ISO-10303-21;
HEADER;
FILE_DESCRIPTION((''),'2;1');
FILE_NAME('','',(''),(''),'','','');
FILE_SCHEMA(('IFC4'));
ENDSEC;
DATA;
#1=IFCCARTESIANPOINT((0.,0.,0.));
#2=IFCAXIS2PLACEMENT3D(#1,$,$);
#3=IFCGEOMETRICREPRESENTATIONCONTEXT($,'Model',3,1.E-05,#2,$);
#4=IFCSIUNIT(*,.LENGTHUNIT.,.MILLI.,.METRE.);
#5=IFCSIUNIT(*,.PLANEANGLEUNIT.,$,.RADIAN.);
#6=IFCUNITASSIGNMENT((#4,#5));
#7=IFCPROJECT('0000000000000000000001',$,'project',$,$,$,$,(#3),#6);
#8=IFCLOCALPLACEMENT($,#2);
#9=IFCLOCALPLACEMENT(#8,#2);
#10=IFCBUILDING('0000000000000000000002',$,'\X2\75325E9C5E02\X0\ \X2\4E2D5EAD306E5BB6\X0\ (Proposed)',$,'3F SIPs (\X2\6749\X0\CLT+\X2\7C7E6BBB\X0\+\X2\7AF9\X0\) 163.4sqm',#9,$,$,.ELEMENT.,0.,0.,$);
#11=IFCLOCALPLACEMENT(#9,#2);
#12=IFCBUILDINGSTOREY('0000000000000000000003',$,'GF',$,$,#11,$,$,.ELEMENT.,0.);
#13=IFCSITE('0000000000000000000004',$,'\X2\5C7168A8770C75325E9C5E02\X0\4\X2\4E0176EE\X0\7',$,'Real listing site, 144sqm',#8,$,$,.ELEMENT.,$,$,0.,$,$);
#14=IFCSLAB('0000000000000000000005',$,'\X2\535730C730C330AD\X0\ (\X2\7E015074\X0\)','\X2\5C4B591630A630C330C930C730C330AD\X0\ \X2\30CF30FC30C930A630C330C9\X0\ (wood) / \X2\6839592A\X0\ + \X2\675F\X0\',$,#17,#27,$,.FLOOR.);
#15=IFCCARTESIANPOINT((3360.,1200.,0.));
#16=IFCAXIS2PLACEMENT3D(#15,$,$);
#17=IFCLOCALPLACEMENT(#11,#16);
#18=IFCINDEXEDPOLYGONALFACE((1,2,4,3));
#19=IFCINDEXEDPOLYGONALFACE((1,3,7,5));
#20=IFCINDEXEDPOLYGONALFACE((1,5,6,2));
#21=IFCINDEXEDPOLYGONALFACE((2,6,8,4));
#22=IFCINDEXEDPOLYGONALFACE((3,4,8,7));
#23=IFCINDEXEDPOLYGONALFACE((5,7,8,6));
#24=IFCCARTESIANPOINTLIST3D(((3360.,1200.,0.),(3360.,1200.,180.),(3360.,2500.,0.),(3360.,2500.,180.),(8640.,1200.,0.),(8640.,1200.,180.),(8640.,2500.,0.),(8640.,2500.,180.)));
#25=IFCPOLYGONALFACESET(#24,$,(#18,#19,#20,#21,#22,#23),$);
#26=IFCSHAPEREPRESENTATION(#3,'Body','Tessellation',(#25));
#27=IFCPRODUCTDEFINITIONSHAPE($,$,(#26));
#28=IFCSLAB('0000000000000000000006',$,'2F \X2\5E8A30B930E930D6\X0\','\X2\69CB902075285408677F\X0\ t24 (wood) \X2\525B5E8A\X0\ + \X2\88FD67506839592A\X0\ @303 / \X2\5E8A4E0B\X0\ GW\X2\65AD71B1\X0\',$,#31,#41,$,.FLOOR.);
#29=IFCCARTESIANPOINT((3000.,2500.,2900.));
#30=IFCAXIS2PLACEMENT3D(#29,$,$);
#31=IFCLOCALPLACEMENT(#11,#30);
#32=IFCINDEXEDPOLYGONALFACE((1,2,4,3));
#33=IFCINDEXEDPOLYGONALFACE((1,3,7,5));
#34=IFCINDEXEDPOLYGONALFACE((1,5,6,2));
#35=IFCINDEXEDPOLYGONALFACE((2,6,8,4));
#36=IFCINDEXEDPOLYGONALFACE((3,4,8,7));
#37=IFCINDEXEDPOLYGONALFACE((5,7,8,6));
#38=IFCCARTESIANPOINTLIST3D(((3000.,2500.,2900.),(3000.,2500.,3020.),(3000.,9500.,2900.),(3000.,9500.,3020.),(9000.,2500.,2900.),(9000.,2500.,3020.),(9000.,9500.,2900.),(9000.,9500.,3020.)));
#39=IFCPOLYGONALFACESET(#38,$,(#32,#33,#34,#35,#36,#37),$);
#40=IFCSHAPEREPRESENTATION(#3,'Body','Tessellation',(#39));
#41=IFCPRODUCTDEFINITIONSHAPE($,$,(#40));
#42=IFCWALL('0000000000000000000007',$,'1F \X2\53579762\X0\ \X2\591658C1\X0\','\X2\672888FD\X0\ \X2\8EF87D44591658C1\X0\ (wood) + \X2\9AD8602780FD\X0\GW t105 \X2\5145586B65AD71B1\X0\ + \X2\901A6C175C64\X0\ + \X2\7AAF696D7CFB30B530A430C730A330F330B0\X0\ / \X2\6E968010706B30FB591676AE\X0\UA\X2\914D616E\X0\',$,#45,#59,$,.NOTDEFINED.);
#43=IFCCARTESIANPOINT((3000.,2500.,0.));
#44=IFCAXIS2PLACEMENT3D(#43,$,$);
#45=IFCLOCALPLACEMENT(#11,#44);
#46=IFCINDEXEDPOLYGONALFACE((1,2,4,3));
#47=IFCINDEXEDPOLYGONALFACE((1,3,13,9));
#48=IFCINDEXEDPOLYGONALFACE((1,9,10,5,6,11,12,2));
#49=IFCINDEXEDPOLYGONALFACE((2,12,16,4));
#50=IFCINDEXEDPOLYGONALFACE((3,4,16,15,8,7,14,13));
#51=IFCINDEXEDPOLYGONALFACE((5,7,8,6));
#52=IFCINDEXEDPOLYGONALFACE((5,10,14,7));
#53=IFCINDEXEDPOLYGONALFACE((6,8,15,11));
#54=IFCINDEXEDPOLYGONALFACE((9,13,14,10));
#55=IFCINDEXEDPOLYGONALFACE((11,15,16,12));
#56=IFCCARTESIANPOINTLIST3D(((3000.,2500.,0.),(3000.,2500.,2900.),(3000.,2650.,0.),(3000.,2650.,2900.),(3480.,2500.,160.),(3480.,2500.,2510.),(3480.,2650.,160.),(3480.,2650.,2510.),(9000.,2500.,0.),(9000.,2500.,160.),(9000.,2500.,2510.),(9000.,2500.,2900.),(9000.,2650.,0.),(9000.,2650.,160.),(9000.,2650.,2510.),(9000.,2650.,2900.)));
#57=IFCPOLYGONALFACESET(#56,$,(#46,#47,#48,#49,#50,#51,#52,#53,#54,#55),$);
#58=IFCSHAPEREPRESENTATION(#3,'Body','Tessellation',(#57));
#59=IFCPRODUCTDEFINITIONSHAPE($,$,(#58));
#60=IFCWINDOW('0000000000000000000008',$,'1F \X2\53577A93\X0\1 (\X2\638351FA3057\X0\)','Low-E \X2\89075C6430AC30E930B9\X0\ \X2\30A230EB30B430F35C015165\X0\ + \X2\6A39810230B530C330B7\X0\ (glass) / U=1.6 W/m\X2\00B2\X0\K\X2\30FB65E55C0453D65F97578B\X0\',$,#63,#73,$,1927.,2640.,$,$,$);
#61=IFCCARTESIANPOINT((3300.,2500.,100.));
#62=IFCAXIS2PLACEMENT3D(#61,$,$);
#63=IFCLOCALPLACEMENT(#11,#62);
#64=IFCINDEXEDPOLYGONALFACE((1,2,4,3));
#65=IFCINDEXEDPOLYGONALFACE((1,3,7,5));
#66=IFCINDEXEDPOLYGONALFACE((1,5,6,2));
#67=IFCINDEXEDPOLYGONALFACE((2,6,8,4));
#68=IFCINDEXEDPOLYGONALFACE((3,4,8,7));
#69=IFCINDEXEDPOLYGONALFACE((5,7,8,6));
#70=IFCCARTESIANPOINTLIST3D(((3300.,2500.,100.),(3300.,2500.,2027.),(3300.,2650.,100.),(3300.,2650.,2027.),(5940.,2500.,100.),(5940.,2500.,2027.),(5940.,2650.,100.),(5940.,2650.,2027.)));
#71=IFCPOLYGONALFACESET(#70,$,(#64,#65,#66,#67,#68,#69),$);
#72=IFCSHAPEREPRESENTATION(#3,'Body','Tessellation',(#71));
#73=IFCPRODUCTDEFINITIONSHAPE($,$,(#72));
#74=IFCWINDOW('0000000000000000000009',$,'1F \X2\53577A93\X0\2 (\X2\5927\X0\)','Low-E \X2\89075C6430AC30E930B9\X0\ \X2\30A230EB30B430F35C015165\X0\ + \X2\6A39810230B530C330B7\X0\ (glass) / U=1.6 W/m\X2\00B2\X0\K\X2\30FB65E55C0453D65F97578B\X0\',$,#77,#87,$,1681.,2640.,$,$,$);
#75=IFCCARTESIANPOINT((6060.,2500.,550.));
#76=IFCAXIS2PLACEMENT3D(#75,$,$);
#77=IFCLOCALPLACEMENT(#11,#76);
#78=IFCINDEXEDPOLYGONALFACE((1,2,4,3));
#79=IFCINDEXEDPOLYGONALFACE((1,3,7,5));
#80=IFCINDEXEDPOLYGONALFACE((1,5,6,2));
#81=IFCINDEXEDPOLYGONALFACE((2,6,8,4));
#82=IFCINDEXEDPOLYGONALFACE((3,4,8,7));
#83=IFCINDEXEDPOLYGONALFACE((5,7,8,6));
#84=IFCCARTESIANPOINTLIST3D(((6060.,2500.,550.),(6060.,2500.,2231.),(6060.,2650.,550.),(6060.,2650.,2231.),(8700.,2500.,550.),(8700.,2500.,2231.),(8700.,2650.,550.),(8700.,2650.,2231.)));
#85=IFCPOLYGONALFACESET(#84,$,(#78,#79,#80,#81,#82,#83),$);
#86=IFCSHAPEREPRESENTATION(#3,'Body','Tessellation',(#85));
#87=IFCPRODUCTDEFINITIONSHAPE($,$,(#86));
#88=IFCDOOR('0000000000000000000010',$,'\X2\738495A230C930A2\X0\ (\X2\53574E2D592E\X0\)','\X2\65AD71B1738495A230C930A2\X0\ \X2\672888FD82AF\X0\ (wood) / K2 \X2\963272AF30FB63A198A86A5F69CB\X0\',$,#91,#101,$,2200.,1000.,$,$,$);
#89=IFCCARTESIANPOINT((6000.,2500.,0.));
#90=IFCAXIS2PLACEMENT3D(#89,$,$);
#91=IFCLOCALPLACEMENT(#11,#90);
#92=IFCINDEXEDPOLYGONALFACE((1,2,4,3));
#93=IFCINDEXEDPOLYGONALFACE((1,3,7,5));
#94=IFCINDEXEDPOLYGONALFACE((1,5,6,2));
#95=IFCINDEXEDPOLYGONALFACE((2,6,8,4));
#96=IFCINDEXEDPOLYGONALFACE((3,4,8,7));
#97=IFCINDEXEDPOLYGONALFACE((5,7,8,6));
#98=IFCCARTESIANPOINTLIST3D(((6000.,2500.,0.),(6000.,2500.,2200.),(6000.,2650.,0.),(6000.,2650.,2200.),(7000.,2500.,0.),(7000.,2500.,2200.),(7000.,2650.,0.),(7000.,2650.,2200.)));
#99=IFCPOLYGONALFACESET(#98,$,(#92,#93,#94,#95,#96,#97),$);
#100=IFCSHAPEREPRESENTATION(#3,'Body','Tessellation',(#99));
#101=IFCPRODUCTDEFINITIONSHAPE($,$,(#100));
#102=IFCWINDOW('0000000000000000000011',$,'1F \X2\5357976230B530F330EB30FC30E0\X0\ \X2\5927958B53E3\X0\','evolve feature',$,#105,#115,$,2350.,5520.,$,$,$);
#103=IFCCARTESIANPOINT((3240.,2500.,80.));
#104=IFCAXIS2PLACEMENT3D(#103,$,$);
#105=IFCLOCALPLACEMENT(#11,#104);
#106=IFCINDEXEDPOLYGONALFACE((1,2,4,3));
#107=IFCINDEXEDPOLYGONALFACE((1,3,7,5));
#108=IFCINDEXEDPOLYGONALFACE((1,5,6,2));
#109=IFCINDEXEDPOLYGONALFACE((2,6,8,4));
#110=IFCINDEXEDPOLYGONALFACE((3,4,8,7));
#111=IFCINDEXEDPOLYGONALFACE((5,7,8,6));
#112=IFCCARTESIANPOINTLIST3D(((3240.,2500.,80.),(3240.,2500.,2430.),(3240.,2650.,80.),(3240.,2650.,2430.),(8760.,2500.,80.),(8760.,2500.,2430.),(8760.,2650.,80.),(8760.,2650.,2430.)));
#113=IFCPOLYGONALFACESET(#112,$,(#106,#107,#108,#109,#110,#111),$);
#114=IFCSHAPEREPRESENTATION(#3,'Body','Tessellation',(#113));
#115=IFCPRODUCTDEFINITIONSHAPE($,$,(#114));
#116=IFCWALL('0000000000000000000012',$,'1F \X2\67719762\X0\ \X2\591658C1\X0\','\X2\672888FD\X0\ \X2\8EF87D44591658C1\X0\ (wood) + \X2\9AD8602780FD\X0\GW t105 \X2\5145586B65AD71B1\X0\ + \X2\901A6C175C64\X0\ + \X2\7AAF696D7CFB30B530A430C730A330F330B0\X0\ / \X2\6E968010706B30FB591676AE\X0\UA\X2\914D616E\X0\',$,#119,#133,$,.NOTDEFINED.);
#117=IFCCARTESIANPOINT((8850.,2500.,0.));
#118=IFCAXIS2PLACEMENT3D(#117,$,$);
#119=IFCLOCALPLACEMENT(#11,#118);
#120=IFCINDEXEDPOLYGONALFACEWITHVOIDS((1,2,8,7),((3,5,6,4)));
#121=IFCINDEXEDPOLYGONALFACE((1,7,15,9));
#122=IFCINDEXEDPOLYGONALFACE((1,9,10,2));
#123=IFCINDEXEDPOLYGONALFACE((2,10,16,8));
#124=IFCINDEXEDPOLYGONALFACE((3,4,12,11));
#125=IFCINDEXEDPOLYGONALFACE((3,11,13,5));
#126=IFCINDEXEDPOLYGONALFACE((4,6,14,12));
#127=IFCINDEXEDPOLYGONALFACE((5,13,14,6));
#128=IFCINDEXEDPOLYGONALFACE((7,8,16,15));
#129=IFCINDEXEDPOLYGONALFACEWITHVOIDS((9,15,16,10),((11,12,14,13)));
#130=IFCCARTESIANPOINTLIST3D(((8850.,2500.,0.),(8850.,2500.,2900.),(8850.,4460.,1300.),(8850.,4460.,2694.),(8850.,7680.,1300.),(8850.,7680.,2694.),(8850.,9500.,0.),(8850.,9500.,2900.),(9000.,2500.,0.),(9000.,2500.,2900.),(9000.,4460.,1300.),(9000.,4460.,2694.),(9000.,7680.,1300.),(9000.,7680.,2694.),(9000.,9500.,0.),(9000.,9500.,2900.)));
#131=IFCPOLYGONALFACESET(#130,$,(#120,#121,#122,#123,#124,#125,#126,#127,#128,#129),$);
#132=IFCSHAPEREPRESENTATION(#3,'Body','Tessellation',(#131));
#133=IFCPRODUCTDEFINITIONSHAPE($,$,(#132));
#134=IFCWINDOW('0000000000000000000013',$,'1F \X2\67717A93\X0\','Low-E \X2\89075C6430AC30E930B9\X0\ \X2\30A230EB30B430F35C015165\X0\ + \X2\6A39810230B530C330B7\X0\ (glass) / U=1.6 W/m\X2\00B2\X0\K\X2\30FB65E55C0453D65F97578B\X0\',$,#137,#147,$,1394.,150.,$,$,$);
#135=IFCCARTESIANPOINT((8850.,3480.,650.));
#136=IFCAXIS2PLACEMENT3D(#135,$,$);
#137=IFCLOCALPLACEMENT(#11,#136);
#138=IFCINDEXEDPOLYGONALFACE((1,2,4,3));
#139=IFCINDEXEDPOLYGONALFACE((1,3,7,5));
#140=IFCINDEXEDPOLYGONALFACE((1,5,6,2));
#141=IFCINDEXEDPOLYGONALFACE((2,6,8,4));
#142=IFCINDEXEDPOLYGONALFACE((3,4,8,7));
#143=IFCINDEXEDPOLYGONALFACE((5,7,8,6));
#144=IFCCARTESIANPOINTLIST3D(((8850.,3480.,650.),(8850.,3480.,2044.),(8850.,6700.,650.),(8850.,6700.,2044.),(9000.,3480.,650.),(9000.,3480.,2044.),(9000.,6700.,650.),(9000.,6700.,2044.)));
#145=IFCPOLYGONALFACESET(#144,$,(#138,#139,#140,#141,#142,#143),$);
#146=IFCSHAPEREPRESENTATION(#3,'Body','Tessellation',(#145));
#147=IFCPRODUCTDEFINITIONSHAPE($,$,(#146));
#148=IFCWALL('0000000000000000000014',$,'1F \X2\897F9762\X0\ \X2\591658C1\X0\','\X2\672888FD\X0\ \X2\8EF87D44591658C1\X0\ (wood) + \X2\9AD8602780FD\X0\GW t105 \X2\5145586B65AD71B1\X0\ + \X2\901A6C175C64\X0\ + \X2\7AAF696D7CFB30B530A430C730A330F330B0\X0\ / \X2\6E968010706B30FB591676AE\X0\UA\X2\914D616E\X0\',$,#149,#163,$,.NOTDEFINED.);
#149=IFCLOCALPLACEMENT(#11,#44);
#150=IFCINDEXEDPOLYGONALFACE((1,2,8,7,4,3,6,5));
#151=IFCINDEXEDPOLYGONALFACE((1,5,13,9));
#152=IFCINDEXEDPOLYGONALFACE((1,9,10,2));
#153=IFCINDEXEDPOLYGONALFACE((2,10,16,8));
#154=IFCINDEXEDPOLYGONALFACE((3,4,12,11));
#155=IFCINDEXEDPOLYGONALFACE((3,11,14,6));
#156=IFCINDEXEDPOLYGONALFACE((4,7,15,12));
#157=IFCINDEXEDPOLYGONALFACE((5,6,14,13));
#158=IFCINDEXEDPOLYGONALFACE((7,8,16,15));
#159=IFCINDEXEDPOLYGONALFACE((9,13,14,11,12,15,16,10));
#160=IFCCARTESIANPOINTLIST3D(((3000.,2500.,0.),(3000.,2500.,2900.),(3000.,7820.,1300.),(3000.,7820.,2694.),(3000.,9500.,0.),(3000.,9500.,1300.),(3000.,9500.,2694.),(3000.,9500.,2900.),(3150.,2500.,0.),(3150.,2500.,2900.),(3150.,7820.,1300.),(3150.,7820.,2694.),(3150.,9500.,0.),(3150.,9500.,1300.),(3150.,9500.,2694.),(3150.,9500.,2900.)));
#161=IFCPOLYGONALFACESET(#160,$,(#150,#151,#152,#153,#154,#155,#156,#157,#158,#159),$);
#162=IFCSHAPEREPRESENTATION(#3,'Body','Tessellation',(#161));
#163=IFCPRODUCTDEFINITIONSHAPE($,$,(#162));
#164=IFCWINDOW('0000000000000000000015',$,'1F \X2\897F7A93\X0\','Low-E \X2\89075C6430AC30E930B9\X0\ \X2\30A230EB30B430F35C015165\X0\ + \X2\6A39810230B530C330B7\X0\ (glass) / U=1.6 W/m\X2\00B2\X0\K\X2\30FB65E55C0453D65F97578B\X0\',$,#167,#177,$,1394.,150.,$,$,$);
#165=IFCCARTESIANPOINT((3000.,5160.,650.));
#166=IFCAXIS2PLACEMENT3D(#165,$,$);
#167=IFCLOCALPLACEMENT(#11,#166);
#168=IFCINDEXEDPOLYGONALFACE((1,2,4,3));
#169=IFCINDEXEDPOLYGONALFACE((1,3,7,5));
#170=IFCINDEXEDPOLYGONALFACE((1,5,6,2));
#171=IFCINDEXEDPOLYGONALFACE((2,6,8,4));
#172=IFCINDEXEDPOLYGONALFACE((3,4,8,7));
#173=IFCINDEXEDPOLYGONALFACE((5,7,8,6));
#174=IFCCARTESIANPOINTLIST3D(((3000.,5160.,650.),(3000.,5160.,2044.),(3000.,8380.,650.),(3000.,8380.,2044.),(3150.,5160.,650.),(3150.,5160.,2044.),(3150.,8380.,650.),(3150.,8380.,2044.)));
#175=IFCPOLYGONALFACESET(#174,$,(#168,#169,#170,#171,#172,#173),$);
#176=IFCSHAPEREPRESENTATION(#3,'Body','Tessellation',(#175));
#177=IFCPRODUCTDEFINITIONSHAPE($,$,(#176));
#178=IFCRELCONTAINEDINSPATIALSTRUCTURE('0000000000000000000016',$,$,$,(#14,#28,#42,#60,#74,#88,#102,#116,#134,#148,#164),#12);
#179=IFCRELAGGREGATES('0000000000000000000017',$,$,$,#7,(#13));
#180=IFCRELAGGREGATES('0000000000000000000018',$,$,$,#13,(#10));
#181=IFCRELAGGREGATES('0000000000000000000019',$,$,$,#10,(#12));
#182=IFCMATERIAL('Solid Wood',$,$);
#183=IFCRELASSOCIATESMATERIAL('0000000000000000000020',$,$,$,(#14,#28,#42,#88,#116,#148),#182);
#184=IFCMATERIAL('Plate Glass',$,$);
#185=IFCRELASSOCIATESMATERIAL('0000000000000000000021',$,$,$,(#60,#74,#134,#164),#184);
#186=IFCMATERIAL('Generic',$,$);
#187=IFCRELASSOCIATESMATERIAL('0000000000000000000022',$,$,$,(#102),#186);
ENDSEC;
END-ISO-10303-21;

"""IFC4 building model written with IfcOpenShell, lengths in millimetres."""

from ifc_helpers import new_model, si_unit, frame, frame_2d, origin, place, context, project, spatial, rectangle, extrude, material, element, fill, save


model = new_model("IFC4")

# Units and contexts
model_context = context("Model", 3, precision=1e-05, world=origin())
ifc_project = project(units=[si_unit("LENGTHUNIT", "METRE", prefix="MILLI"), si_unit("PLANEANGLEUNIT", "RADIAN")], contexts=[model_context])

# Site, building, storey
site_placement = place(None, origin())
site = spatial("IfcSite", under=ifc_project, at=site_placement, Name="山梨県甲府市4丁目7", ObjectType="Real listing site, 144sqm", CompositionType="ELEMENT", RefElevation=0.0)
building_placement = place(site_placement, origin())
building = spatial("IfcBuilding", under=site, at=building_placement, Name="甲府市 中庭の家 (Proposed)", ObjectType="3F SIPs (杉CLT+籾殻+竹) 163.4sqm", CompositionType="ELEMENT", ElevationOfRefHeight=0.0, ElevationOfTerrain=0.0)
storey_placement = place(building_placement, origin())
storey = spatial("IfcBuildingStorey", under=building, at=storey_placement, Name="GF", CompositionType="ELEMENT", Elevation=0.0)

# Slabs
ifc_material_1 = material(Name="Solid Wood")
slab_1_placement = place(storey_placement, frame((3360.0, 1200.0, 0.0)))
element("IfcSlab", 1, at=slab_1_placement, inside=storey, material=ifc_material_1, Name="南デッキ (縁側)", Description="屋外ウッドデッキ ハードウッド (wood) / 根太 + 束", PredefinedType="FLOOR", context=model_context, shape_type="SweptSolid", body=[
    extrude(rectangle(XDim=5280.0, YDim=1300.0, at=frame_2d((2640.0, 650.0))), frame((3360.0, 1200.0, 0.0)), (0.0, 0.0, 1.0), 180.0),
])
slab_2_placement = place(storey_placement, frame((3000.0, 2500.0, 2900.0)))
element("IfcSlab", 2, at=slab_2_placement, inside=storey, material=ifc_material_1, Name="2F 床スラブ", Description="構造用合板 t24 (wood) 剛床 + 製材根太 @303 / 床下 GW断熱", PredefinedType="FLOOR", context=model_context, shape_type="SweptSolid", body=[
    extrude(rectangle(XDim=6000.0, YDim=7000.0, at=frame_2d((3000.0, 3500.0))), frame((3000.0, 2500.0, 2900.0)), (0.0, 0.0, 1.0), 120.0),
])

# Wall, openings, windows, door
wall_1_placement = place(storey_placement, frame((3000.0, 2500.0, 0.0)))
wall_1 = element("IfcWall", 3, at=wall_1_placement, inside=storey, material=ifc_material_1, Name="1F 南面 外壁", Description="木製 軸組外壁 (wood) + 高性能GW t105 充填断熱 + 通気層 + 窯業系サイディング / 準耐火・外皮UA配慮", PredefinedType="NOTDEFINED", context=model_context, shape_type="SweptSolid", body=[
    extrude(rectangle(XDim=6000.0, YDim=150.0, at=frame_2d((3000.0, 75.0))), frame((3000.0, 2500.0, 0.0)), (0.0, 0.0, 1.0), 2900.0),
])
opening_1_placement = place(storey_placement, frame((3300.0, 2500.0, 100.0)))
opening_1 = element("IfcOpeningElement", 4, at=opening_1_placement, cuts=wall_1, PredefinedType="NOTDEFINED", context=model_context, shape_type="SweptSolid", body=[
    extrude(rectangle(XDim=2640.0, YDim=150.0, at=frame_2d((1320.0, 75.0))), frame((3300.0, 2500.0, 100.0)), (0.0, 0.0, 1.0), 1927.0),
])
opening_2_placement = place(storey_placement, frame((6060.0, 2500.0, 550.0)))
opening_2 = element("IfcOpeningElement", 5, at=opening_2_placement, cuts=wall_1, PredefinedType="NOTDEFINED", context=model_context, shape_type="SweptSolid", body=[
    extrude(rectangle(XDim=2640.0, YDim=150.0, at=frame_2d((1320.0, 75.0))), frame((6060.0, 2500.0, 550.0)), (0.0, 0.0, 1.0), 1681.0),
])
opening_3_placement = place(storey_placement, frame((6000.0, 2500.0, 0.0)))
opening_3 = element("IfcOpeningElement", 6, at=opening_3_placement, cuts=wall_1, PredefinedType="NOTDEFINED", context=model_context, shape_type="SweptSolid", body=[
    extrude(rectangle(XDim=1000.0, YDim=150.0, at=frame_2d((500.0, 75.0))), frame((6000.0, 2500.0, 0.0)), (0.0, 0.0, 1.0), 2200.0),
])
opening_4_placement = place(storey_placement, frame((3240.0, 2500.0, 80.0)))
opening_4 = element("IfcOpeningElement", 7, at=opening_4_placement, cuts=wall_1, PredefinedType="NOTDEFINED", context=model_context, shape_type="SweptSolid", body=[
    extrude(rectangle(XDim=5520.0, YDim=150.0, at=frame_2d((2760.0, 75.0))), frame((3240.0, 2500.0, 80.0)), (0.0, 0.0, 1.0), 2350.0),
])
ifc_material_2 = material(Name="Plate Glass")
window_1_placement = place(storey_placement, frame((3300.0, 2500.0, 100.0)))
window_1 = element("IfcWindow", 8, at=window_1_placement, inside=storey, material=ifc_material_2, Name="1F 南窓1 (掃出し)", Description="Low-E 複層ガラス アルゴン封入 + 樹脂サッシ (glass) / U=1.6 W/m²K・日射取得型", OverallHeight=1927.0, OverallWidth=2640.0, context=model_context, shape_type="SweptSolid", body=[
    extrude(rectangle(XDim=2640.0, YDim=150.0, at=frame_2d((1320.0, 75.0))), frame((3300.0, 2500.0, 100.0)), (0.0, 0.0, 1.0), 1927.0),
])
fill(opening_1, window_1)
window_2_placement = place(storey_placement, frame((6060.0, 2500.0, 550.0)))
window_2 = element("IfcWindow", 9, at=window_2_placement, inside=storey, material=ifc_material_2, Name="1F 南窓2 (大)", Description="Low-E 複層ガラス アルゴン封入 + 樹脂サッシ (glass) / U=1.6 W/m²K・日射取得型", OverallHeight=1681.0, OverallWidth=2640.0, context=model_context, shape_type="SweptSolid", body=[
    extrude(rectangle(XDim=2640.0, YDim=150.0, at=frame_2d((1320.0, 75.0))), frame((6060.0, 2500.0, 550.0)), (0.0, 0.0, 1.0), 1681.0),
])
fill(opening_2, window_2)
door_placement = place(storey_placement, frame((6000.0, 2500.0, 0.0)))
door = element("IfcDoor", 10, at=door_placement, inside=storey, material=ifc_material_1, Name="玄関ドア (南中央)", Description="断熱玄関ドア 木製芯 (wood) / K2 防犯・採風機構", OverallHeight=2200.0, OverallWidth=1000.0, context=model_context, shape_type="SweptSolid", body=[
    extrude(rectangle(XDim=1000.0, YDim=150.0, at=frame_2d((500.0, 75.0))), frame((6000.0, 2500.0, 0.0)), (0.0, 0.0, 1.0), 2200.0),
])
fill(opening_3, door)
ifc_material_3 = material(Name="Generic")
window_3_placement = place(storey_placement, frame((3240.0, 2500.0, 80.0)))
window_3 = element("IfcWindow", 11, at=window_3_placement, inside=storey, material=ifc_material_3, Name="1F 南面サンルーム 大開口", Description="evolve feature", OverallHeight=2350.0, OverallWidth=5520.0, context=model_context, shape_type="SweptSolid", body=[
    extrude(rectangle(XDim=5520.0, YDim=150.0, at=frame_2d((2760.0, 75.0))), frame((3240.0, 2500.0, 80.0)), (0.0, 0.0, 1.0), 2350.0),
])
fill(opening_4, window_3)

# Walls, openings, windows
wall_2_placement = place(storey_placement, frame((8850.0, 2500.0, 0.0)))
wall_2 = element("IfcWall", 12, at=wall_2_placement, inside=storey, material=ifc_material_1, Name="1F 東面 外壁", Description="木製 軸組外壁 (wood) + 高性能GW t105 充填断熱 + 通気層 + 窯業系サイディング / 準耐火・外皮UA配慮", PredefinedType="NOTDEFINED", context=model_context, shape_type="SweptSolid", body=[
    extrude(rectangle(XDim=150.0, YDim=7000.0, at=frame_2d((75.0, 3500.0))), frame((8850.0, 2500.0, 0.0)), (0.0, 0.0, 1.0), 2900.0),
])
opening_5_placement = place(storey_placement, frame((8850.0, 3480.0, 650.0)))
opening_5 = element("IfcOpeningElement", 13, at=opening_5_placement, cuts=wall_2, PredefinedType="NOTDEFINED", context=model_context, shape_type="SweptSolid", body=[
    extrude(rectangle(XDim=150.0, YDim=3220.0, at=frame_2d((75.0, 1610.0))), frame((8850.0, 3480.0, 650.0)), (0.0, 0.0, 1.0), 1394.0),
])
window_4_placement = place(storey_placement, frame((8850.0, 3480.0, 650.0)))
window_4 = element("IfcWindow", 14, at=window_4_placement, inside=storey, material=ifc_material_2, Name="1F 東窓", Description="Low-E 複層ガラス アルゴン封入 + 樹脂サッシ (glass) / U=1.6 W/m²K・日射取得型", OverallHeight=1394.0, OverallWidth=150.0, context=model_context, shape_type="SweptSolid", body=[
    extrude(rectangle(XDim=150.0, YDim=3220.0, at=frame_2d((75.0, 1610.0))), frame((8850.0, 3480.0, 650.0)), (0.0, 0.0, 1.0), 1394.0),
])
fill(opening_5, window_4)
wall_3_placement = place(storey_placement, frame((3000.0, 2500.0, 0.0)))
wall_3 = element("IfcWall", 15, at=wall_3_placement, inside=storey, material=ifc_material_1, Name="1F 西面 外壁", Description="木製 軸組外壁 (wood) + 高性能GW t105 充填断熱 + 通気層 + 窯業系サイディング / 準耐火・外皮UA配慮", PredefinedType="NOTDEFINED", context=model_context, shape_type="SweptSolid", body=[
    extrude(rectangle(XDim=150.0, YDim=7000.0, at=frame_2d((75.0, 3500.0))), frame((3000.0, 2500.0, 0.0)), (0.0, 0.0, 1.0), 2900.0),
])
opening_6_placement = place(storey_placement, frame((3000.0, 5160.0, 650.0)))
opening_6 = element("IfcOpeningElement", 16, at=opening_6_placement, cuts=wall_3, PredefinedType="NOTDEFINED", context=model_context, shape_type="SweptSolid", body=[
    extrude(rectangle(XDim=150.0, YDim=3220.0, at=frame_2d((75.0, 1610.0))), frame((3000.0, 5160.0, 650.0)), (0.0, 0.0, 1.0), 1394.0),
])
window_5_placement = place(storey_placement, frame((3000.0, 5160.0, 650.0)))
window_5 = element("IfcWindow", 17, at=window_5_placement, inside=storey, material=ifc_material_2, Name="1F 西窓", Description="Low-E 複層ガラス アルゴン封入 + 樹脂サッシ (glass) / U=1.6 W/m²K・日射取得型", OverallHeight=1394.0, OverallWidth=150.0, context=model_context, shape_type="SweptSolid", body=[
    extrude(rectangle(XDim=150.0, YDim=3220.0, at=frame_2d((75.0, 1610.0))), frame((3000.0, 5160.0, 650.0)), (0.0, 0.0, 1.0), 1394.0),
])
fill(opening_6, window_5)

save(model, "model.ifc")
